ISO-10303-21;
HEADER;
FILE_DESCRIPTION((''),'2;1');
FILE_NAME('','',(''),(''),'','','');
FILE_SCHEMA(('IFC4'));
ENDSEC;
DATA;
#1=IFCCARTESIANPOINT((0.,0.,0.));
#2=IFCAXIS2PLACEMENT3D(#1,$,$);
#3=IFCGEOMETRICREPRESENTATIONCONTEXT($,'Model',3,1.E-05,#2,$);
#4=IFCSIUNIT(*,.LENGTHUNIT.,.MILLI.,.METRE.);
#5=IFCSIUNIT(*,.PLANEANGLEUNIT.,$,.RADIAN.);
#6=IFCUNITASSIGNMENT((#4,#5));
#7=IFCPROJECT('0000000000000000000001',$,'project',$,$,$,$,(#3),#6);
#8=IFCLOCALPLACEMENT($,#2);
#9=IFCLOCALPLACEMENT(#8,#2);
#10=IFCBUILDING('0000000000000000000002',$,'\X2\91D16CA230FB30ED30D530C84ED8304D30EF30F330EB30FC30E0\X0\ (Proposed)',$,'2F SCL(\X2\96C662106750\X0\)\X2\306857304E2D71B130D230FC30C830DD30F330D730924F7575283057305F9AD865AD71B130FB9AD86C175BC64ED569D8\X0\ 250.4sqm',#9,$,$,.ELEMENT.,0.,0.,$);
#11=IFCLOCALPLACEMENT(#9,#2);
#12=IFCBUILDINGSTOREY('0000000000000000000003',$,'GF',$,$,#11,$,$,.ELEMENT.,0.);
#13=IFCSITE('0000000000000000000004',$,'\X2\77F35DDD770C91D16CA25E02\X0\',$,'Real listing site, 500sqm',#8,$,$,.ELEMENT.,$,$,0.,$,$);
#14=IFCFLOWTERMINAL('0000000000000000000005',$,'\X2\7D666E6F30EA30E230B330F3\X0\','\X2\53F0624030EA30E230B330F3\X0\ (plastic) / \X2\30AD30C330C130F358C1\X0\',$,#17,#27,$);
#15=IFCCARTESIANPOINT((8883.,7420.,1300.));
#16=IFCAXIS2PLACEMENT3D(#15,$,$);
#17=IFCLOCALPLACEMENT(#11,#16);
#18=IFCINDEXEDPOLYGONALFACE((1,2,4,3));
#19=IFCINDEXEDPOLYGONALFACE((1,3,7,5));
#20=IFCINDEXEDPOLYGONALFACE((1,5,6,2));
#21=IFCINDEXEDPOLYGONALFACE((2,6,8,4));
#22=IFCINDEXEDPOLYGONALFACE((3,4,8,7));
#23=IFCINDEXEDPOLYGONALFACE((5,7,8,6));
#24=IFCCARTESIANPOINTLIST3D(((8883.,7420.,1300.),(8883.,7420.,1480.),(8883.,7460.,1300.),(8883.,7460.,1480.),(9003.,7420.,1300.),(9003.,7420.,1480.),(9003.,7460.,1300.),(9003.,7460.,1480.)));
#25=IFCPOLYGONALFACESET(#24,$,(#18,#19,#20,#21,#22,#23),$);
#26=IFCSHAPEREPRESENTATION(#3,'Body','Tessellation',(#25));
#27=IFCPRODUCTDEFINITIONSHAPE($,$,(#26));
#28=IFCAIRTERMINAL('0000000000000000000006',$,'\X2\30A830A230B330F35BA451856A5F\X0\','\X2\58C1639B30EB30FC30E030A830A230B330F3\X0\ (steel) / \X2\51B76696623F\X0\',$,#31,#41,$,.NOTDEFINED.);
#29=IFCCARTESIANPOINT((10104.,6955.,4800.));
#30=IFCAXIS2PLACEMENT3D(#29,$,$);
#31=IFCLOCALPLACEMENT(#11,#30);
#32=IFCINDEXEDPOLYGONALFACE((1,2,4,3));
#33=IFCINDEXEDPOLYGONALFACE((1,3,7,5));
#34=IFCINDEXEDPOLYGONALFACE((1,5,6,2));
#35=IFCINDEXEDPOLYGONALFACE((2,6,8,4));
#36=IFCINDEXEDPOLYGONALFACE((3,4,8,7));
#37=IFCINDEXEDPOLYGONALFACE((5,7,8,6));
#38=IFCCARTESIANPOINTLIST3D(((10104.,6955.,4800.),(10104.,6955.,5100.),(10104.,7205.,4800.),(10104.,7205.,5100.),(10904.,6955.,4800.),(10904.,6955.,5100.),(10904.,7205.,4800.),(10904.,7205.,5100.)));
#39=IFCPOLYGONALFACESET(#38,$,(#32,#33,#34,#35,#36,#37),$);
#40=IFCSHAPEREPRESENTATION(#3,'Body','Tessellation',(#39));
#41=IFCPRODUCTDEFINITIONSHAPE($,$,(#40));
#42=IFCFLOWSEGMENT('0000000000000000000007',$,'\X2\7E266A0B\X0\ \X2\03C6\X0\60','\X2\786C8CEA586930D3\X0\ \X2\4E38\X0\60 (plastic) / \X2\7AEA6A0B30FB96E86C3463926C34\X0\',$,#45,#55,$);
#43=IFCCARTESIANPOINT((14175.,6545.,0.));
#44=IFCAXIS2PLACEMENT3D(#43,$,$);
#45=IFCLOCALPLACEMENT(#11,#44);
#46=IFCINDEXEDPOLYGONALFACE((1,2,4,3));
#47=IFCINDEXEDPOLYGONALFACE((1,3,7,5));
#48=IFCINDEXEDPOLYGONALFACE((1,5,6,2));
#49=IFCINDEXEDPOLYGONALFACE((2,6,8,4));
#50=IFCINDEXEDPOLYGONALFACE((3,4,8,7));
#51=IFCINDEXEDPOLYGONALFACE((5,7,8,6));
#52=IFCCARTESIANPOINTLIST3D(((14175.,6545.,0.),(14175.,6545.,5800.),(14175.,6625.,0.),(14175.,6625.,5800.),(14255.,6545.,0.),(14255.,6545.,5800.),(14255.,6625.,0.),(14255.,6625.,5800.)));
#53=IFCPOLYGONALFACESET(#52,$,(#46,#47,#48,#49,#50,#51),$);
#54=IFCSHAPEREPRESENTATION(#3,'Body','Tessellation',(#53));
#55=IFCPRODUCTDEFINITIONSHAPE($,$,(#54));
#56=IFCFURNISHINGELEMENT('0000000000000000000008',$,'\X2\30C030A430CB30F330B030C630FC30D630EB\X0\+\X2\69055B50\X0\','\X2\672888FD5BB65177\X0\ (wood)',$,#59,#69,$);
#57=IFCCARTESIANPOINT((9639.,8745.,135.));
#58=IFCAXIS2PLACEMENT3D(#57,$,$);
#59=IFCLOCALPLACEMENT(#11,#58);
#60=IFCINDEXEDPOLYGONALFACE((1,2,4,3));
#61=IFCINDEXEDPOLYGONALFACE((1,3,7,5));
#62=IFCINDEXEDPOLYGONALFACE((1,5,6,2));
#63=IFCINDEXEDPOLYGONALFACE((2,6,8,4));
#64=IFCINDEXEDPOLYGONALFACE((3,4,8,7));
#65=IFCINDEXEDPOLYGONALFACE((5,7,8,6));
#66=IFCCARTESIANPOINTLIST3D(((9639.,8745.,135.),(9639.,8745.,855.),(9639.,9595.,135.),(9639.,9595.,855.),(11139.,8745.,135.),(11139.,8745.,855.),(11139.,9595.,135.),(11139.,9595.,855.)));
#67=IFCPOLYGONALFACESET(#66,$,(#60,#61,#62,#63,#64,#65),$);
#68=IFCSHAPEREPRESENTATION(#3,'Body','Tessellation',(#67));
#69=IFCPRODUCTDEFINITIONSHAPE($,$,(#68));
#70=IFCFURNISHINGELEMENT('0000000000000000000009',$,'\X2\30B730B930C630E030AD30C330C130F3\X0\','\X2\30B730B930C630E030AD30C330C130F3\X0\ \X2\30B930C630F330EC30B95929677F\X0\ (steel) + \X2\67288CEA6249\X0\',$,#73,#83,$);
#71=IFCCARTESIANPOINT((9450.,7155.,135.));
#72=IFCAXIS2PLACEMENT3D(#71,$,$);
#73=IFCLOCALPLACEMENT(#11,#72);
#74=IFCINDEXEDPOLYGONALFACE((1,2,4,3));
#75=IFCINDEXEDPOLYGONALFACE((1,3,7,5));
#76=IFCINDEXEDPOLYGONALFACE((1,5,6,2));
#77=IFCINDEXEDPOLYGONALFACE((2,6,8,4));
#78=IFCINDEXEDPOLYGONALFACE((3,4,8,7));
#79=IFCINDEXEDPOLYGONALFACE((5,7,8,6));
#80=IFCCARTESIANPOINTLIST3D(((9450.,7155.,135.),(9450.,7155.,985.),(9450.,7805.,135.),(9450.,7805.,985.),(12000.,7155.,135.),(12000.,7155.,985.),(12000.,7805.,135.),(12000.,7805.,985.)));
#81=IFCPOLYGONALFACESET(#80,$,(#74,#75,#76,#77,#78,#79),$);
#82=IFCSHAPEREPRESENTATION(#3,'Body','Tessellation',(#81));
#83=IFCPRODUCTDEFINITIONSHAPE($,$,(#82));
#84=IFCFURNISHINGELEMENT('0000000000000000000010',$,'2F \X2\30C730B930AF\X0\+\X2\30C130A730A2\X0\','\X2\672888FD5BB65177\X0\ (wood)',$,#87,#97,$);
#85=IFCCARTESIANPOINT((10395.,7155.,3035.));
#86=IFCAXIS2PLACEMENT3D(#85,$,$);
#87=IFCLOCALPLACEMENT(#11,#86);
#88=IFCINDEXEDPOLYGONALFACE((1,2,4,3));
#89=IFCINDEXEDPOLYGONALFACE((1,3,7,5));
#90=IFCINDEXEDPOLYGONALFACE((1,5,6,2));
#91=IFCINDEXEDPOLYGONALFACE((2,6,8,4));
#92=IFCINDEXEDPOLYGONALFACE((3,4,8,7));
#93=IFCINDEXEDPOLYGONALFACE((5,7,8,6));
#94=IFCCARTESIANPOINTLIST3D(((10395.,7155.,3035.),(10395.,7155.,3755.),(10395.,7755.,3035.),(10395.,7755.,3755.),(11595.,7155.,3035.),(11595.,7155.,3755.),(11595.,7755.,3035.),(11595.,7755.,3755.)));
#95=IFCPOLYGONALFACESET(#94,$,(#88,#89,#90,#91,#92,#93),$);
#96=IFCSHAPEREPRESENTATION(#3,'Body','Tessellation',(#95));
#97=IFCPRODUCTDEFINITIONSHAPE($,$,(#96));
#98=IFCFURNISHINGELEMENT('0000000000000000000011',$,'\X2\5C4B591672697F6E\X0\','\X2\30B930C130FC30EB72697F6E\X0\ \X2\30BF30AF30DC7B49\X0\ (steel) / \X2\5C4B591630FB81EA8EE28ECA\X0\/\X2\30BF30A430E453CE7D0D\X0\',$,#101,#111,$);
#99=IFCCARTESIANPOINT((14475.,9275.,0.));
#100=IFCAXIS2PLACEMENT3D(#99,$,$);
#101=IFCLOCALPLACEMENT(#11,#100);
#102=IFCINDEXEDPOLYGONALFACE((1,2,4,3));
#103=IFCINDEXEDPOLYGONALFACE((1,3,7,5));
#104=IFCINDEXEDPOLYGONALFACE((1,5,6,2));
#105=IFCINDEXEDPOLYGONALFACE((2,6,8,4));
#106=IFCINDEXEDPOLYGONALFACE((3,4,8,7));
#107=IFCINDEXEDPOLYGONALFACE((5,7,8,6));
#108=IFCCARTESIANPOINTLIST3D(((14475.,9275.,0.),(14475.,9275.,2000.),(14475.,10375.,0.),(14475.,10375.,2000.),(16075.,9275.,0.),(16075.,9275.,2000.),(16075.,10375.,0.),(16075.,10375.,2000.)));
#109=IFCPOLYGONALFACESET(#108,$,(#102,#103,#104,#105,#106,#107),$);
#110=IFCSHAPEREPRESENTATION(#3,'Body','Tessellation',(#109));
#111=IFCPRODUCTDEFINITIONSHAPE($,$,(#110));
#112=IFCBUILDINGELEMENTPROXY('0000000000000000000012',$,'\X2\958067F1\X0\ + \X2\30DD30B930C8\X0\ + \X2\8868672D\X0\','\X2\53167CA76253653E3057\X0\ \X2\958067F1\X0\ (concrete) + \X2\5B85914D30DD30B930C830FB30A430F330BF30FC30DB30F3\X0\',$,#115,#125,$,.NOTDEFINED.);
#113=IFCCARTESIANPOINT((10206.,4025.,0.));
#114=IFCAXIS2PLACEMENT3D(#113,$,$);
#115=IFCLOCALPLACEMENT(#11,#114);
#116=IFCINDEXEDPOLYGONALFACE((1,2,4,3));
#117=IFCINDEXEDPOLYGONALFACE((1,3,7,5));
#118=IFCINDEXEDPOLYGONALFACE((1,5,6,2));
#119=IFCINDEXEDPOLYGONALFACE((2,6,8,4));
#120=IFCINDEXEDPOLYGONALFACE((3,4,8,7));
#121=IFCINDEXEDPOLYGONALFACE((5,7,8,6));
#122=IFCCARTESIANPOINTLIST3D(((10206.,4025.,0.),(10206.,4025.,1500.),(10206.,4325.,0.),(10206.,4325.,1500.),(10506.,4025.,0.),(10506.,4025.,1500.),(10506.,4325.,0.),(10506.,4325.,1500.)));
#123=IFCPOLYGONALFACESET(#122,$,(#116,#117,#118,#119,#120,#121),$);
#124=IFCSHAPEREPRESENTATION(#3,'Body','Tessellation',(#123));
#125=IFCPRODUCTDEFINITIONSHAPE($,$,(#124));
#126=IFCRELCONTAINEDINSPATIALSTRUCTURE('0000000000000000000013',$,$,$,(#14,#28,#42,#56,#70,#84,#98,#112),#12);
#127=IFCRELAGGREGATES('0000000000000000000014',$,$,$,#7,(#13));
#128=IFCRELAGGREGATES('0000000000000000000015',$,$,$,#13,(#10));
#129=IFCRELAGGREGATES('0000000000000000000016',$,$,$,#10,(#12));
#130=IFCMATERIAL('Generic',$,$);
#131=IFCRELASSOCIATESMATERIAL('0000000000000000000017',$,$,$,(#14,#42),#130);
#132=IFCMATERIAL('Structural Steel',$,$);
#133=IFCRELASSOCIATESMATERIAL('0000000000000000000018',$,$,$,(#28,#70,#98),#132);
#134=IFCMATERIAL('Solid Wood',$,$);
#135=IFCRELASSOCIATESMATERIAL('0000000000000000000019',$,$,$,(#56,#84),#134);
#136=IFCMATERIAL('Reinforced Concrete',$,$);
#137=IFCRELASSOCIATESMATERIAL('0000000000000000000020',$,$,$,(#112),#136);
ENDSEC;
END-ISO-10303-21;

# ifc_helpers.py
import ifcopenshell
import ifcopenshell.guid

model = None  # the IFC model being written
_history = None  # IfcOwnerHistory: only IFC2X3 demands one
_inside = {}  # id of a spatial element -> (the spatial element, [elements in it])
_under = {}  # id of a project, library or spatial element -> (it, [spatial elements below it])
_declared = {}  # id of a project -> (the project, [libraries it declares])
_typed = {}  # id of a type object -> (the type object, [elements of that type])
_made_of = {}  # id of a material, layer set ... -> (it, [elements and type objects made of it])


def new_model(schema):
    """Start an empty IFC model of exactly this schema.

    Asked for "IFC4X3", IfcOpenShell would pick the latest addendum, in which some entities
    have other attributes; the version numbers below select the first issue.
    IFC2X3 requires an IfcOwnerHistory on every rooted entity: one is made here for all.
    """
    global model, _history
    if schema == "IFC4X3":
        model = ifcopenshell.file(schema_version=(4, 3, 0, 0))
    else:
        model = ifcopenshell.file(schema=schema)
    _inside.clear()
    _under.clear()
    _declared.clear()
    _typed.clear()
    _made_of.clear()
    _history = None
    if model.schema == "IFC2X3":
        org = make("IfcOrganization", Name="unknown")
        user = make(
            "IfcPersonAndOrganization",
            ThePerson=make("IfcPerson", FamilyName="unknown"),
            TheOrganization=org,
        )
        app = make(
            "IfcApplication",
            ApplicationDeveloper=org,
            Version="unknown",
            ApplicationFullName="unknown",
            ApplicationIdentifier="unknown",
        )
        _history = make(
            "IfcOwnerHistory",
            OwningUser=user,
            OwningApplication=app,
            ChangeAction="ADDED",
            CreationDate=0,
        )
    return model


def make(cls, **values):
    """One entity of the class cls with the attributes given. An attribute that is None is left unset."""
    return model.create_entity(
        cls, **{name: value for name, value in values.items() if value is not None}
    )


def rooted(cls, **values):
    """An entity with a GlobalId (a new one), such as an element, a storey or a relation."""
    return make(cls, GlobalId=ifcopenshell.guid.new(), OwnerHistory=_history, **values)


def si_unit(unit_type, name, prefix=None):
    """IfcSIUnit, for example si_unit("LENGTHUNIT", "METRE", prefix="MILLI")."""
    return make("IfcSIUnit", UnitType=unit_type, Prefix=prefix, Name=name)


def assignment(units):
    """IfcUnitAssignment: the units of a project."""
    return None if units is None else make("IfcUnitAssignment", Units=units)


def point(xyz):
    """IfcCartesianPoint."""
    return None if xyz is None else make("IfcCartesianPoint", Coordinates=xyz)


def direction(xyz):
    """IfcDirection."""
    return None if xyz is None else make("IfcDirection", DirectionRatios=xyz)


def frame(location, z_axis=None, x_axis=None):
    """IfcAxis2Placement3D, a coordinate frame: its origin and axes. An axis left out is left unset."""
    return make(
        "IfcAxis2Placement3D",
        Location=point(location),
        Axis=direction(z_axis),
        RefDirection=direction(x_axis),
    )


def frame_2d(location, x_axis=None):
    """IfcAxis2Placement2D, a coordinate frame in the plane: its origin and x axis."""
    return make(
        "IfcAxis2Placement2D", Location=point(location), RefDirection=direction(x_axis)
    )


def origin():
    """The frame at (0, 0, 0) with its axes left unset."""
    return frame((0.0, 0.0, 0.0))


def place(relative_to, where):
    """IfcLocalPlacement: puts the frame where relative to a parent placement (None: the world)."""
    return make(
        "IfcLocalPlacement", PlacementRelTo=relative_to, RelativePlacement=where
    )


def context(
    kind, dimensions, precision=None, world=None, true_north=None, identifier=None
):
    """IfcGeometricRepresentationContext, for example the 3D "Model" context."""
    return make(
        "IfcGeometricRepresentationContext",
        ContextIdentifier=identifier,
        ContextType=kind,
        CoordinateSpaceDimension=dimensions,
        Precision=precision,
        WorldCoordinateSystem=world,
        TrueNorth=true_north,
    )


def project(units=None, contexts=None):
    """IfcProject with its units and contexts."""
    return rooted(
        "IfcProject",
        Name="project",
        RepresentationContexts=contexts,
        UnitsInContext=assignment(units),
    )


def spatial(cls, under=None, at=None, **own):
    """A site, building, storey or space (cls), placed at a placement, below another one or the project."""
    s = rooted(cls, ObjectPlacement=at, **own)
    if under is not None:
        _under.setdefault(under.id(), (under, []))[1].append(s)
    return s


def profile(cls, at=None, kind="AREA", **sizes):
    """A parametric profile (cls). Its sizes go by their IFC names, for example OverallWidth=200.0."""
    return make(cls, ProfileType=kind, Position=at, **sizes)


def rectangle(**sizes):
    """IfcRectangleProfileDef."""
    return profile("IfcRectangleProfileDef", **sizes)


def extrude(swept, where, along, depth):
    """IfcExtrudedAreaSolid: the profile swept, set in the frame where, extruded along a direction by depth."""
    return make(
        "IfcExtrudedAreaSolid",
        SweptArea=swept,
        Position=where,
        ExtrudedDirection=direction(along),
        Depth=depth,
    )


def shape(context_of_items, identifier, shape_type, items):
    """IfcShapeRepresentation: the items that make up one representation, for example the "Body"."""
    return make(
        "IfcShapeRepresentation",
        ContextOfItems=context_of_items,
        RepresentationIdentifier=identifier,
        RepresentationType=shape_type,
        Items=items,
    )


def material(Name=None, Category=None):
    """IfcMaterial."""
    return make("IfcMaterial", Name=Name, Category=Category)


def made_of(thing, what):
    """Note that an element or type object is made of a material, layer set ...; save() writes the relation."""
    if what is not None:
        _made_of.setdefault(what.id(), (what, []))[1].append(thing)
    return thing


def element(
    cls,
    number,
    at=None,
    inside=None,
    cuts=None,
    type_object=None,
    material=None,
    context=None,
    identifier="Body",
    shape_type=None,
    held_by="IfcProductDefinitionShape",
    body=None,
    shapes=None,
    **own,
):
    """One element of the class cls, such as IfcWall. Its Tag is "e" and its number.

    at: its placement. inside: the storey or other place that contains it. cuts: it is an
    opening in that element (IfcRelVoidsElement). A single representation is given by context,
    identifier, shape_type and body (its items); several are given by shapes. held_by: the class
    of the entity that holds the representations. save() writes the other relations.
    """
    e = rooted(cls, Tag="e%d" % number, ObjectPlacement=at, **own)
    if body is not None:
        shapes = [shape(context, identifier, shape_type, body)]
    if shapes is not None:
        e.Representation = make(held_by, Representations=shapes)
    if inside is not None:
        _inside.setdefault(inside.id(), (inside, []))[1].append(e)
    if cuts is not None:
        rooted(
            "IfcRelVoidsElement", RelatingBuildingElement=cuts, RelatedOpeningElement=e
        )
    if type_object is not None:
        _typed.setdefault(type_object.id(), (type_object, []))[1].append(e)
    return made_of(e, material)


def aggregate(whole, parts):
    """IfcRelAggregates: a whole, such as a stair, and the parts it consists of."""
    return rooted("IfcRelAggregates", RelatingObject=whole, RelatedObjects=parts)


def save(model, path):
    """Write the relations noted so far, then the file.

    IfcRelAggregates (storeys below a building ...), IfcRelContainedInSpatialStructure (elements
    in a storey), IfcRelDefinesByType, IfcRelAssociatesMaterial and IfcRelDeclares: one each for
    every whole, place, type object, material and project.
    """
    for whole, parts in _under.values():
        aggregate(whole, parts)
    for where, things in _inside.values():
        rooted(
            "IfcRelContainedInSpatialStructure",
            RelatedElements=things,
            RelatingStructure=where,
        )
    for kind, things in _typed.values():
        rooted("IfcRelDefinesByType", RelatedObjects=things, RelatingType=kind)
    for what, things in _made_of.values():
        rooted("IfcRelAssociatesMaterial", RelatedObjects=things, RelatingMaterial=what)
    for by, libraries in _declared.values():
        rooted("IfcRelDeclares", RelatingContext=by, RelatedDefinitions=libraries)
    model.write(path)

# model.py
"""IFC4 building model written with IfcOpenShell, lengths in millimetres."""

from ifc_helpers import new_model, si_unit, frame, frame_2d, origin, place, context, project, spatial, rectangle, extrude, material, element, save


model = new_model("IFC4")

# Units and contexts
model_context = context("Model", 3, precision=1e-05, world=origin())
ifc_project = project(units=[si_unit("LENGTHUNIT", "METRE", prefix="MILLI"), si_unit("PLANEANGLEUNIT", "RADIAN")], contexts=[model_context])

# Site, building, storey
site_placement = place(None, origin())
site = spatial("IfcSite", under=ifc_project, at=site_placement, Name="石川県金沢市", ObjectType="Real listing site, 500sqm", CompositionType="ELEMENT", RefElevation=0.0)
building_placement = place(site_placement, origin())
building = spatial("IfcBuilding", under=site, at=building_placement, Name="金沢・ロフト付きワンルーム (Proposed)", ObjectType="2F SCL(集成材)と地中熱ヒートポンプを併用した高断熱・高気密仕様 250.4sqm", CompositionType="ELEMENT", ElevationOfRefHeight=0.0, ElevationOfTerrain=0.0)
storey_placement = place(building_placement, origin())
storey = spatial("IfcBuildingStorey", under=building, at=storey_placement, Name="GF", CompositionType="ELEMENT", Elevation=0.0)

# Shared definitions
ifc_material_1 = material(Name="Solid Wood")

# Shared definitions
ifc_material_2 = material(Name="Reinforced Concrete")

# Shared definitions
ifc_material_3 = material(Name="Structural Steel")

# Flow terminal
ifc_material_4 = material(Name="Generic")
flow_terminal_1_placement = place(storey_placement, frame((8883.0, 7420.0, 1300.0)))
element("IfcFlowTerminal", 1, at=flow_terminal_1_placement, inside=storey, material=ifc_material_4, Name="給湯リモコン", Description="台所リモコン (plastic) / キッチン壁", context=model_context, shape_type="SweptSolid", body=[
    extrude(rectangle(XDim=120.0, YDim=40.0, at=frame_2d((60.0, 20.0))), frame((8883.0, 7420.0, 1300.0)), (0.0, 0.0, 1.0), 180.0),
])

# Air terminal
air_terminal_placement = place(storey_placement, frame((10104.0, 6955.0, 4800.0)))
element("IfcAirTerminal", 2, at=air_terminal_placement, inside=storey, material=ifc_material_3, Name="エアコン室内機", Description="壁掛ルームエアコン (steel) / 冷暖房", PredefinedType="NOTDEFINED", context=model_context, shape_type="SweptSolid", body=[
    extrude(rectangle(XDim=800.0, YDim=250.0, at=frame_2d((400.0, 125.0))), frame((10104.0, 6955.0, 4800.0)), (0.0, 0.0, 1.0), 300.0),
])

# Flow segment
flow_segment_placement = place(storey_placement, frame((14175.0, 6545.0, 0.0)))
element("IfcFlowSegment", 3, at=flow_segment_placement, inside=storey, material=ifc_material_4, Name="縦樋 φ60", Description="硬質塩ビ 丸60 (plastic) / 竪樋・雨水排水", context=model_context, shape_type="SweptSolid", body=[
    extrude(rectangle(XDim=80.0, YDim=80.0, at=frame_2d((40.0, 40.0))), frame((14175.0, 6545.0, 0.0)), (0.0, 0.0, 1.0), 5800.0),
])

# Furnishing elements
furnishing_1_placement = place(storey_placement, frame((9639.0, 8745.0, 135.0)))
element("IfcFurnishingElement", 4, at=furnishing_1_placement, inside=storey, material=ifc_material_1, Name="ダイニングテーブル+椅子", Description="木製家具 (wood)", context=model_context, shape_type="SweptSolid", body=[
    extrude(rectangle(XDim=1500.0, YDim=850.0, at=frame_2d((750.0, 425.0))), frame((9639.0, 8745.0, 135.0)), (0.0, 0.0, 1.0), 720.0),
])
furnishing_2_placement = place(storey_placement, frame((9450.0, 7155.0, 135.0)))
element("IfcFurnishingElement", 5, at=furnishing_2_placement, inside=storey, material=ifc_material_3, Name="システムキッチン", Description="システムキッチン ステンレス天板 (steel) + 木質扉", context=model_context, shape_type="SweptSolid", body=[
    extrude(rectangle(XDim=2550.0, YDim=650.0, at=frame_2d((1275.0, 325.0))), frame((9450.0, 7155.0, 135.0)), (0.0, 0.0, 1.0), 850.0),
])
furnishing_3_placement = place(storey_placement, frame((10395.0, 7155.0, 3035.0)))
element("IfcFurnishingElement", 6, at=furnishing_3_placement, inside=storey, material=ifc_material_1, Name="2F デスク+チェア", Description="木製家具 (wood)", context=model_context, shape_type="SweptSolid", body=[
    extrude(rectangle(XDim=1200.0, YDim=600.0, at=frame_2d((600.0, 300.0))), frame((10395.0, 7155.0, 3035.0)), (0.0, 0.0, 1.0), 720.0),
])
furnishing_4_placement = place(storey_placement, frame((14475.0, 9275.0, 0.0)))
element("IfcFurnishingElement", 7, at=furnishing_4_placement, inside=storey, material=ifc_material_3, Name="屋外物置", Description="スチール物置 タクボ等 (steel) / 屋外・自転車/タイヤ収納", context=model_context, shape_type="SweptSolid", body=[
    extrude(rectangle(XDim=1600.0, YDim=1100.0, at=frame_2d((800.0, 550.0))), frame((14475.0, 9275.0, 0.0)), (0.0, 0.0, 1.0), 2000.0),
])

# Building element proxy
proxy_placement = place(storey_placement, frame((10206.0, 4025.0, 0.0)))
element("IfcBuildingElementProxy", 8, at=proxy_placement, inside=storey, material=ifc_material_2, Name="門柱 + ポスト + 表札", Description="化粧打放し 門柱 (concrete) + 宅配ポスト・インターホン", PredefinedType="NOTDEFINED", context=model_context, shape_type="SweptSolid", body=[
    extrude(rectangle(XDim=300.0, YDim=300.0, at=frame_2d((150.0, 150.0))), frame((10206.0, 4025.0, 0.0)), (0.0, 0.0, 1.0), 1500.0),
])

save(model, "model.ifc")
